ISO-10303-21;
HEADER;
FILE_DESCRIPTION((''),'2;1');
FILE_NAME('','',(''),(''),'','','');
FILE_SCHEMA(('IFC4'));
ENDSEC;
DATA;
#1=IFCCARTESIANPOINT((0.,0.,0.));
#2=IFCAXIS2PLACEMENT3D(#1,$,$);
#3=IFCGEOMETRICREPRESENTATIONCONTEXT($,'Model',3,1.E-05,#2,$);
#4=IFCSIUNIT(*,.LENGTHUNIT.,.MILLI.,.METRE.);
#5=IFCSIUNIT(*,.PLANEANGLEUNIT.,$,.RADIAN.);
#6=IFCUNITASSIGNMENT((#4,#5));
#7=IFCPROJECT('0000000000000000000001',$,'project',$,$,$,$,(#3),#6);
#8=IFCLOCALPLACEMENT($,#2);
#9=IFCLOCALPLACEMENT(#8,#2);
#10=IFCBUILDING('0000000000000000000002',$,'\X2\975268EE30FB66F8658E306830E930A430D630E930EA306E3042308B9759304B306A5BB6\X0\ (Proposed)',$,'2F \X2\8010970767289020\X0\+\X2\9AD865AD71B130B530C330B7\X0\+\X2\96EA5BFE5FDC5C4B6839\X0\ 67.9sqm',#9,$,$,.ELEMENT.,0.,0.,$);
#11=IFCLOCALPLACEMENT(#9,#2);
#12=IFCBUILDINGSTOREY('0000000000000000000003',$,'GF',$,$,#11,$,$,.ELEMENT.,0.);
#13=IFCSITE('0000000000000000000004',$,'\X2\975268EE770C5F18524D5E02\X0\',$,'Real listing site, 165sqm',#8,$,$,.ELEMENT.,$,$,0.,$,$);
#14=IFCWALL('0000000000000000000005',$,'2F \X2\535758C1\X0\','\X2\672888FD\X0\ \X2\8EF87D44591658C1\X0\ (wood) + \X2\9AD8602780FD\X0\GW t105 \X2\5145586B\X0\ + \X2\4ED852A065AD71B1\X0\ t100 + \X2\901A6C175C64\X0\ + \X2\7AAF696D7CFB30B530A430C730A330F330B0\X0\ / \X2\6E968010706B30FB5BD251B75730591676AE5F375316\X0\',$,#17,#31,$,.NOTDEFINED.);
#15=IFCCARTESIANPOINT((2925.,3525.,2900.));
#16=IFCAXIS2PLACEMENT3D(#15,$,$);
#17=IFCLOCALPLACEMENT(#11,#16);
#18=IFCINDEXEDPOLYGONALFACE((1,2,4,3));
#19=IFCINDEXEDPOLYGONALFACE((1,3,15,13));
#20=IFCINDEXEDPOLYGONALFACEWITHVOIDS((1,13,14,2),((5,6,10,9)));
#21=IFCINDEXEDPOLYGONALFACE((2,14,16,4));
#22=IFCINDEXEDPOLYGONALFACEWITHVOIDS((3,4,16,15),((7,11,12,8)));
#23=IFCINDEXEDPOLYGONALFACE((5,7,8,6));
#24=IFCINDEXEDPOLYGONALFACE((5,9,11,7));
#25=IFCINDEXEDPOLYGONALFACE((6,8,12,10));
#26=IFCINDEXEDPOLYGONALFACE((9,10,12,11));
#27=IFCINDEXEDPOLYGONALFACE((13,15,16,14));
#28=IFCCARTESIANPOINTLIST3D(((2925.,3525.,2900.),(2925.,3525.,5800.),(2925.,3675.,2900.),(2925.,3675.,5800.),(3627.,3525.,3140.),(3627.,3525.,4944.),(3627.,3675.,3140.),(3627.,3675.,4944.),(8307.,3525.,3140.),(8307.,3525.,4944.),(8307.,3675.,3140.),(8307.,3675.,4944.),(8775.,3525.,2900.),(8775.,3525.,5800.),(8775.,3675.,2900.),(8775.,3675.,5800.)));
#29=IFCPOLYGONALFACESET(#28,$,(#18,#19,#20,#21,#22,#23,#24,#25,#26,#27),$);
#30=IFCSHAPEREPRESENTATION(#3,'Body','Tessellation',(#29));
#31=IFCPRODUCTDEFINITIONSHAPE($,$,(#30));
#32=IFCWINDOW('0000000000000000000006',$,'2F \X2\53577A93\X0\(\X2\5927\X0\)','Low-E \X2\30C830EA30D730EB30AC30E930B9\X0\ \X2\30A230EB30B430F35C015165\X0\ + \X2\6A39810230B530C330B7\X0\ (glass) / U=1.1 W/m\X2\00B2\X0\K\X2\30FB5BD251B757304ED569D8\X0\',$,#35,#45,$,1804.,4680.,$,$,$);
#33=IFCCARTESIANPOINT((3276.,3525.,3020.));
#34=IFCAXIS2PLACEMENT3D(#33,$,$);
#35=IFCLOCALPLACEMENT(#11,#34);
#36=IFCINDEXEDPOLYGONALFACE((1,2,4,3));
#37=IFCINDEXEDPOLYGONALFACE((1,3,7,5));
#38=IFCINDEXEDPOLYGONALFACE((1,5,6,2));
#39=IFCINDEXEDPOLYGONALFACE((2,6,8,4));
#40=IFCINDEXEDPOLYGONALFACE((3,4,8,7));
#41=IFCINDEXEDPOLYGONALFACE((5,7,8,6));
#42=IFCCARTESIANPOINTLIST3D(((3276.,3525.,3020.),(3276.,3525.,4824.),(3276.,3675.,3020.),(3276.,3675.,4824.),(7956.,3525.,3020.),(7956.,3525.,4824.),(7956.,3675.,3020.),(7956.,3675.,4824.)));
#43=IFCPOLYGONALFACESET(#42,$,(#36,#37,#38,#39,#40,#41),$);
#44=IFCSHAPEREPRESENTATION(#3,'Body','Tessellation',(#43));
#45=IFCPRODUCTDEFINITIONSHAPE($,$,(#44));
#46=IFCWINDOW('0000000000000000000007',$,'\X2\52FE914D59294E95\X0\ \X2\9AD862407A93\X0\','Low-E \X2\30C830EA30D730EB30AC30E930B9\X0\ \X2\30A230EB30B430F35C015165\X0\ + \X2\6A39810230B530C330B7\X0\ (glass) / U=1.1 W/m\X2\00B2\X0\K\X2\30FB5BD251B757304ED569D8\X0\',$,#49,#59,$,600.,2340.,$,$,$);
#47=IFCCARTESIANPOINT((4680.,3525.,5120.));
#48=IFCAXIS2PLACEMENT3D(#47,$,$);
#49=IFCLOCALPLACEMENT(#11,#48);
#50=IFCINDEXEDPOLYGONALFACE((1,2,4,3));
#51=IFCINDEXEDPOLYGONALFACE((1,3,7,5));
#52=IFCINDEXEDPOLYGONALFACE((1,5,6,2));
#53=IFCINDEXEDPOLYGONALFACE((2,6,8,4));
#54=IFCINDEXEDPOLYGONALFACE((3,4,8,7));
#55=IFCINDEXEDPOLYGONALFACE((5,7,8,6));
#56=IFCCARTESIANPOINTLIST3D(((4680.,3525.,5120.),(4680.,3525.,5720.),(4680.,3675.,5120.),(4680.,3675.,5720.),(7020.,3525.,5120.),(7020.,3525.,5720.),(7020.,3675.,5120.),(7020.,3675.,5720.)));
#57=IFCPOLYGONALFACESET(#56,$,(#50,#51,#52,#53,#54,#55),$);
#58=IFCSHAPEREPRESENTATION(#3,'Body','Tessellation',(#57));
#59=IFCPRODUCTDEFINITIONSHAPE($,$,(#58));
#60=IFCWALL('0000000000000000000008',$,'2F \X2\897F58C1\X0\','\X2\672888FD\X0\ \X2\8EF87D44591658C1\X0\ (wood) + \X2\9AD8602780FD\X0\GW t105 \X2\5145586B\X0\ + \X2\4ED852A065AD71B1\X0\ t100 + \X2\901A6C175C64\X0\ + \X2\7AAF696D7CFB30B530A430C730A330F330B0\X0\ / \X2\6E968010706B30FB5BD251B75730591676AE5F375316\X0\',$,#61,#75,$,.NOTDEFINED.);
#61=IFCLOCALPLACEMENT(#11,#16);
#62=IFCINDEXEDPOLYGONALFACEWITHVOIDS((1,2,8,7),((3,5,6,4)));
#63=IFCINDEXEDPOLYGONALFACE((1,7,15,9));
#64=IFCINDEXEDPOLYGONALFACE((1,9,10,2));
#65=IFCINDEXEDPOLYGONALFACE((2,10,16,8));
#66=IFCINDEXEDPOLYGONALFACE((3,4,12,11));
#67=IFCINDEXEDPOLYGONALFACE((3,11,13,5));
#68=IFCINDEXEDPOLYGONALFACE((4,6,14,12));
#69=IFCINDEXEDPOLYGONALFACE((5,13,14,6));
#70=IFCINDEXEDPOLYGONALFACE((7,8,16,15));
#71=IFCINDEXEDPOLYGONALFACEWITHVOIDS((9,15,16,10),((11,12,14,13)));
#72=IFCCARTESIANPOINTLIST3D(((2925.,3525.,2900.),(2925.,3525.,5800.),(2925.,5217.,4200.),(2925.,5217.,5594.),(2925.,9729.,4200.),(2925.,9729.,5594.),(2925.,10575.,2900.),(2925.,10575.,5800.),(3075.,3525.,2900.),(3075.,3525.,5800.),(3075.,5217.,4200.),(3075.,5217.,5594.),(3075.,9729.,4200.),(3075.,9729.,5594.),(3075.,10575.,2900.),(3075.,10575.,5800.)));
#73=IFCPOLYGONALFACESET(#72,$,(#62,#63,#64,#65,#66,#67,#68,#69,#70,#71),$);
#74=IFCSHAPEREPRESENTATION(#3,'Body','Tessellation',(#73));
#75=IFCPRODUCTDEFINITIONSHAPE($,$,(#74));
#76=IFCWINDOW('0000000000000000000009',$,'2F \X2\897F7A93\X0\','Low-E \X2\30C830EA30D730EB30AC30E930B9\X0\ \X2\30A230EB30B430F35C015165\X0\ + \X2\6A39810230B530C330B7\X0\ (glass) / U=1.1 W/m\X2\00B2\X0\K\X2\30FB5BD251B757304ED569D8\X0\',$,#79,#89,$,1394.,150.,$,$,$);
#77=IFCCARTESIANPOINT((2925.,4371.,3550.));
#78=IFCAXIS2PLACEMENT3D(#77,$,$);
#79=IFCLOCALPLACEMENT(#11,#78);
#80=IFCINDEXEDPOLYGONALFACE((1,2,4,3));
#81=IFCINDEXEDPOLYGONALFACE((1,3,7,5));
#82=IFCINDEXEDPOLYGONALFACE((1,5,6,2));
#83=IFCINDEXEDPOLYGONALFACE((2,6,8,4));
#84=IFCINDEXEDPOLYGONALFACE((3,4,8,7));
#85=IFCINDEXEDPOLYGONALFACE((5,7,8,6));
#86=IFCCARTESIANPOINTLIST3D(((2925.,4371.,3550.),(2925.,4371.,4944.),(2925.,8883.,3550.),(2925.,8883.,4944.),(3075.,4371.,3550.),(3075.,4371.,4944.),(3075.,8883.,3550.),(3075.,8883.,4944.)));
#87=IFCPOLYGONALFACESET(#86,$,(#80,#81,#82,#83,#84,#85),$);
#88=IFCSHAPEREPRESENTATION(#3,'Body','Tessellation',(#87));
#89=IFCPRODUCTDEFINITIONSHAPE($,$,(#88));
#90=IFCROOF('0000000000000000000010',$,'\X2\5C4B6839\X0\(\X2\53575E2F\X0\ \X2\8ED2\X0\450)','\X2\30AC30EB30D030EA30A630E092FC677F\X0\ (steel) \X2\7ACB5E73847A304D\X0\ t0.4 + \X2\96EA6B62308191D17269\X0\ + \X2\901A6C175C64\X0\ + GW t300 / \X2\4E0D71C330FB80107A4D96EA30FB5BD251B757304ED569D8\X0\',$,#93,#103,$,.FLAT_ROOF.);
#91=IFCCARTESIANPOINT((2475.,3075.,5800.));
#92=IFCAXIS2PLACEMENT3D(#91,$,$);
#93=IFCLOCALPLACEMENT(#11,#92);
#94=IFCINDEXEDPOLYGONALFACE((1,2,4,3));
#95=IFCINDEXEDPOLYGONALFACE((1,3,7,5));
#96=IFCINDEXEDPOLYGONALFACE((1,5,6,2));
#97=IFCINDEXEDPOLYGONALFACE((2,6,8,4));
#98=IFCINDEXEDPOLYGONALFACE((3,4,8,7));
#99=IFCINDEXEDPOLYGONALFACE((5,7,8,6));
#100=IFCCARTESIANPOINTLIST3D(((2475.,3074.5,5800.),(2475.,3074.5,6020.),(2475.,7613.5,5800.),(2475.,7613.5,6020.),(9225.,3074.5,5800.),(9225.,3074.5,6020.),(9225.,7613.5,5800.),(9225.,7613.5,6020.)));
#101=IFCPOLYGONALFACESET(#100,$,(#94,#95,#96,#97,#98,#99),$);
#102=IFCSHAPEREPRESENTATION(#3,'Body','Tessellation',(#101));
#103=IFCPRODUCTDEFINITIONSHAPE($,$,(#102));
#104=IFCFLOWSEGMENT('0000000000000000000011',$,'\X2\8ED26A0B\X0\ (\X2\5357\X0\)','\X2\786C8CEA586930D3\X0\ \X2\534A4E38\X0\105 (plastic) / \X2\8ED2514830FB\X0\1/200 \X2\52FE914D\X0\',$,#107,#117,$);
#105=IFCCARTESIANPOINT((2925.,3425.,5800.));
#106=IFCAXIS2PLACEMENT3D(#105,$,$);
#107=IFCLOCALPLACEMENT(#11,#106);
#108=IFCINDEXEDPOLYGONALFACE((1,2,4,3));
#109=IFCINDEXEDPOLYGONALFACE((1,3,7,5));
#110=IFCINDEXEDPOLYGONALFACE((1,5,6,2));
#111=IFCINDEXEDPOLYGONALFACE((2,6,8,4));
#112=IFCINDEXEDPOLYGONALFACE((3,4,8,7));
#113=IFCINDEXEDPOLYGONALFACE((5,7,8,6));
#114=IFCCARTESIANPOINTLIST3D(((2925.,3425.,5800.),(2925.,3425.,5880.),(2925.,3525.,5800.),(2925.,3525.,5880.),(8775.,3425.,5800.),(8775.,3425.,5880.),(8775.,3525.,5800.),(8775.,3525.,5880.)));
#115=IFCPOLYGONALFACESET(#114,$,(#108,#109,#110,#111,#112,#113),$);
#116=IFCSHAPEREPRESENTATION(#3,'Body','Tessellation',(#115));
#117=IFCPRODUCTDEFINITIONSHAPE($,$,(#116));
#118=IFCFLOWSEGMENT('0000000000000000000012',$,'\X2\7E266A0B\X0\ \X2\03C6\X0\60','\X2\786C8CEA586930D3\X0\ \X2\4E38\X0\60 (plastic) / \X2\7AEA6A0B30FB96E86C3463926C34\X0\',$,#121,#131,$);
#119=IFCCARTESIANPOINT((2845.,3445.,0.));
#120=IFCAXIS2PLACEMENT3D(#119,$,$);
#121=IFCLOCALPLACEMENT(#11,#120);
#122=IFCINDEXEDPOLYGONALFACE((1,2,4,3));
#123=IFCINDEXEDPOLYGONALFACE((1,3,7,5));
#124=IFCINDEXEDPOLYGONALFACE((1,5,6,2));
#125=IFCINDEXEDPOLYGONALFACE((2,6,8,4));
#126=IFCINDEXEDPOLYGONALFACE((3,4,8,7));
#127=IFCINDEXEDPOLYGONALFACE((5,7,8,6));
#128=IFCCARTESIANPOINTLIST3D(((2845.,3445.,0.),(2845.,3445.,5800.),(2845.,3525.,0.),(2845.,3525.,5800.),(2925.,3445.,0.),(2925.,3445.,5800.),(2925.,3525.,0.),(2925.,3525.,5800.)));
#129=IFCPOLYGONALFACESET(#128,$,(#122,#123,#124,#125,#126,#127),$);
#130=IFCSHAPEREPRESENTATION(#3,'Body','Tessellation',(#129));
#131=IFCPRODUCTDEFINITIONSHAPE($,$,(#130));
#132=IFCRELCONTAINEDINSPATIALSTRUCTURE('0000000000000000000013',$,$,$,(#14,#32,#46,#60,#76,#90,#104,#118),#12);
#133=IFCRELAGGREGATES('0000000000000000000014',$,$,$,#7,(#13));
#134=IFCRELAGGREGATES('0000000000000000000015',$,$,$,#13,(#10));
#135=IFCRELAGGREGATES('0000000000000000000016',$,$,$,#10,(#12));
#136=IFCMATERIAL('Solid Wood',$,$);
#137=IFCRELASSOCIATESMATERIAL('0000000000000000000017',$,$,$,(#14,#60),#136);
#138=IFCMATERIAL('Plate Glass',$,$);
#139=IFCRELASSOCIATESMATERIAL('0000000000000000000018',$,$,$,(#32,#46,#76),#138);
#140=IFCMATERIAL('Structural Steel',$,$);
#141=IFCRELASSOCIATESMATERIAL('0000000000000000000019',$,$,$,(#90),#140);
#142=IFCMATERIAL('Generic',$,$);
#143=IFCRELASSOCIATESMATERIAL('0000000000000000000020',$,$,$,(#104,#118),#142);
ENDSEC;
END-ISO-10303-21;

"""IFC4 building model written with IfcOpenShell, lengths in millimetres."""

from ifc_helpers import new_model, si_unit, frame, frame_2d, origin, place, context, project, spatial, rectangle, extrude, material, element, fill, save


model = new_model("IFC4")

# Units and contexts
model_context = context("Model", 3, precision=1e-05, world=origin())
ifc_project = project(units=[si_unit("LENGTHUNIT", "METRE", prefix="MILLI"), si_unit("PLANEANGLEUNIT", "RADIAN")], contexts=[model_context])

# Site, building, storey
site_placement = place(None, origin())
site = spatial("IfcSite", under=ifc_project, at=site_placement, Name="青森県弘前市", ObjectType="Real listing site, 165sqm", CompositionType="ELEMENT", RefElevation=0.0)
building_placement = place(site_placement, origin())
building = spatial("IfcBuilding", under=site, at=building_placement, Name="青森・書斎とライブラリのある静かな家 (Proposed)", ObjectType="2F 耐震木造+高断熱サッシ+雪対応屋根 67.9sqm", CompositionType="ELEMENT", ElevationOfRefHeight=0.0, ElevationOfTerrain=0.0)
storey_placement = place(building_placement, origin())
storey = spatial("IfcBuildingStorey", under=building, at=storey_placement, Name="GF", CompositionType="ELEMENT", Elevation=0.0)

# Shared definitions
ifc_material_1 = material(Name="Solid Wood")

# Shared definitions
ifc_material_2 = material(Name="Plate Glass")

# Wall, openings, windows
wall_1_placement = place(storey_placement, frame((2925.0, 3525.0, 2900.0)))
wall_1 = element("IfcWall", 1, at=wall_1_placement, inside=storey, material=ifc_material_1, Name="2F 南壁", Description="木製 軸組外壁 (wood) + 高性能GW t105 充填 + 付加断熱 t100 + 通気層 + 窯業系サイディング / 準耐火・寒冷地外皮強化", PredefinedType="NOTDEFINED", context=model_context, shape_type="SweptSolid", body=[
    extrude(rectangle(XDim=5850.0, YDim=150.0, at=frame_2d((2925.0, 75.0))), frame((2925.0, 3525.0, 2900.0)), (0.0, 0.0, 1.0), 2900.0),
])
opening_1_placement = place(storey_placement, frame((3276.0, 3525.0, 3020.0)))
opening_1 = element("IfcOpeningElement", 2, at=opening_1_placement, cuts=wall_1, PredefinedType="NOTDEFINED", context=model_context, shape_type="SweptSolid", body=[
    extrude(rectangle(XDim=4680.0, YDim=150.0, at=frame_2d((2340.0, 75.0))), frame((3276.0, 3525.0, 3020.0)), (0.0, 0.0, 1.0), 1804.0),
])
opening_2_placement = place(storey_placement, frame((4680.0, 3525.0, 5120.0)))
opening_2 = element("IfcOpeningElement", 3, at=opening_2_placement, cuts=wall_1, PredefinedType="NOTDEFINED", context=model_context, shape_type="SweptSolid", body=[
    extrude(rectangle(XDim=2340.0, YDim=150.0, at=frame_2d((1170.0, 75.0))), frame((4680.0, 3525.0, 5120.0)), (0.0, 0.0, 1.0), 600.0),
])
window_1_placement = place(storey_placement, frame((3276.0, 3525.0, 3020.0)))
window_1 = element("IfcWindow", 4, at=window_1_placement, inside=storey, material=ifc_material_2, Name="2F 南窓(大)", Description="Low-E トリプルガラス アルゴン封入 + 樹脂サッシ (glass) / U=1.1 W/m²K・寒冷地仕様", OverallHeight=1804.0, OverallWidth=4680.0, context=model_context, shape_type="SweptSolid", body=[
    extrude(rectangle(XDim=4680.0, YDim=150.0, at=frame_2d((2340.0, 75.0))), frame((3276.0, 3525.0, 3020.0)), (0.0, 0.0, 1.0), 1804.0),
])
fill(opening_1, window_1)
window_2_placement = place(storey_placement, frame((4680.0, 3525.0, 5120.0)))
window_2 = element("IfcWindow", 5, at=window_2_placement, inside=storey, material=ifc_material_2, Name="勾配天井 高所窓", Description="Low-E トリプルガラス アルゴン封入 + 樹脂サッシ (glass) / U=1.1 W/m²K・寒冷地仕様", OverallHeight=600.0, OverallWidth=2340.0, context=model_context, shape_type="SweptSolid", body=[
    extrude(rectangle(XDim=2340.0, YDim=150.0, at=frame_2d((1170.0, 75.0))), frame((4680.0, 3525.0, 5120.0)), (0.0, 0.0, 1.0), 600.0),
])
fill(opening_2, window_2)

# Wall, opening, window
wall_2_placement = place(storey_placement, frame((2925.0, 3525.0, 2900.0)))
wall_2 = element("IfcWall", 6, at=wall_2_placement, inside=storey, material=ifc_material_1, Name="2F 西壁", Description="木製 軸組外壁 (wood) + 高性能GW t105 充填 + 付加断熱 t100 + 通気層 + 窯業系サイディング / 準耐火・寒冷地外皮強化", PredefinedType="NOTDEFINED", context=model_context, shape_type="SweptSolid", body=[
    extrude(rectangle(XDim=150.0, YDim=7050.0, at=frame_2d((75.0, 3525.0))), frame((2925.0, 3525.0, 2900.0)), (0.0, 0.0, 1.0), 2900.0),
])
opening_3_placement = place(storey_placement, frame((2925.0, 4371.0, 3550.0)))
opening_3 = element("IfcOpeningElement", 7, at=opening_3_placement, cuts=wall_2, PredefinedType="NOTDEFINED", context=model_context, shape_type="SweptSolid", body=[
    extrude(rectangle(XDim=150.0, YDim=4512.0, at=frame_2d((75.0, 2256.0))), frame((2925.0, 4371.0, 3550.0)), (0.0, 0.0, 1.0), 1394.0),
])
window_3_placement = place(storey_placement, frame((2925.0, 4371.0, 3550.0)))
window_3 = element("IfcWindow", 8, at=window_3_placement, inside=storey, material=ifc_material_2, Name="2F 西窓", Description="Low-E トリプルガラス アルゴン封入 + 樹脂サッシ (glass) / U=1.1 W/m²K・寒冷地仕様", OverallHeight=1394.0, OverallWidth=150.0, context=model_context, shape_type="SweptSolid", body=[
    extrude(rectangle(XDim=150.0, YDim=4512.0, at=frame_2d((75.0, 2256.0))), frame((2925.0, 4371.0, 3550.0)), (0.0, 0.0, 1.0), 1394.0),
])
fill(opening_3, window_3)

# Roof
ifc_material_3 = material(Name="Structural Steel")
for number, where, name in (
    (9, (2475.0, 3075.0, 5800.0), "屋根(南帯 軒450)"),
):
    element("IfcRoof", number, at=place(storey_placement, frame(where)), inside=storey, material=ifc_material_3, Name=name, Description="ガルバリウム鋼板 (steel) 立平葺き t0.4 + 雪止め金物 + 通気層 + GW t300 / 不燃・耐積雪・寒冷地仕様", PredefinedType="FLAT_ROOF", context=model_context, shape_type="SweptSolid", body=[
        extrude(rectangle(XDim=6750.0, YDim=4539.0, at=frame_2d((3375.0, 2269.0))), frame((2475.0, 3075.0, 5800.0)), (0.0, 0.0, 1.0), 220.0),
    ])

# Flow segments
ifc_material_4 = material(Name="Generic")
flow_segment_1_placement = place(storey_placement, frame((2925.0, 3425.0, 5800.0)))
element("IfcFlowSegment", 10, at=flow_segment_1_placement, inside=storey, material=ifc_material_4, Name="軒樋 (南)", Description="硬質塩ビ 半丸105 (plastic) / 軒先・1/200 勾配", context=model_context, shape_type="SweptSolid", body=[
    extrude(rectangle(XDim=5850.0, YDim=100.0, at=frame_2d((2925.0, 50.0))), frame((2925.0, 3425.0, 5800.0)), (0.0, 0.0, 1.0), 80.0),
])
flow_segment_2_placement = place(storey_placement, frame((2845.0, 3445.0, 0.0)))
element("IfcFlowSegment", 11, at=flow_segment_2_placement, inside=storey, material=ifc_material_4, Name="縦樋 φ60", Description="硬質塩ビ 丸60 (plastic) / 竪樋・雨水排水", context=model_context, shape_type="SweptSolid", body=[
    extrude(rectangle(XDim=80.0, YDim=80.0, at=frame_2d((40.0, 40.0))), frame((2845.0, 3445.0, 0.0)), (0.0, 0.0, 1.0), 5800.0),
])

save(model, "model.ifc")
